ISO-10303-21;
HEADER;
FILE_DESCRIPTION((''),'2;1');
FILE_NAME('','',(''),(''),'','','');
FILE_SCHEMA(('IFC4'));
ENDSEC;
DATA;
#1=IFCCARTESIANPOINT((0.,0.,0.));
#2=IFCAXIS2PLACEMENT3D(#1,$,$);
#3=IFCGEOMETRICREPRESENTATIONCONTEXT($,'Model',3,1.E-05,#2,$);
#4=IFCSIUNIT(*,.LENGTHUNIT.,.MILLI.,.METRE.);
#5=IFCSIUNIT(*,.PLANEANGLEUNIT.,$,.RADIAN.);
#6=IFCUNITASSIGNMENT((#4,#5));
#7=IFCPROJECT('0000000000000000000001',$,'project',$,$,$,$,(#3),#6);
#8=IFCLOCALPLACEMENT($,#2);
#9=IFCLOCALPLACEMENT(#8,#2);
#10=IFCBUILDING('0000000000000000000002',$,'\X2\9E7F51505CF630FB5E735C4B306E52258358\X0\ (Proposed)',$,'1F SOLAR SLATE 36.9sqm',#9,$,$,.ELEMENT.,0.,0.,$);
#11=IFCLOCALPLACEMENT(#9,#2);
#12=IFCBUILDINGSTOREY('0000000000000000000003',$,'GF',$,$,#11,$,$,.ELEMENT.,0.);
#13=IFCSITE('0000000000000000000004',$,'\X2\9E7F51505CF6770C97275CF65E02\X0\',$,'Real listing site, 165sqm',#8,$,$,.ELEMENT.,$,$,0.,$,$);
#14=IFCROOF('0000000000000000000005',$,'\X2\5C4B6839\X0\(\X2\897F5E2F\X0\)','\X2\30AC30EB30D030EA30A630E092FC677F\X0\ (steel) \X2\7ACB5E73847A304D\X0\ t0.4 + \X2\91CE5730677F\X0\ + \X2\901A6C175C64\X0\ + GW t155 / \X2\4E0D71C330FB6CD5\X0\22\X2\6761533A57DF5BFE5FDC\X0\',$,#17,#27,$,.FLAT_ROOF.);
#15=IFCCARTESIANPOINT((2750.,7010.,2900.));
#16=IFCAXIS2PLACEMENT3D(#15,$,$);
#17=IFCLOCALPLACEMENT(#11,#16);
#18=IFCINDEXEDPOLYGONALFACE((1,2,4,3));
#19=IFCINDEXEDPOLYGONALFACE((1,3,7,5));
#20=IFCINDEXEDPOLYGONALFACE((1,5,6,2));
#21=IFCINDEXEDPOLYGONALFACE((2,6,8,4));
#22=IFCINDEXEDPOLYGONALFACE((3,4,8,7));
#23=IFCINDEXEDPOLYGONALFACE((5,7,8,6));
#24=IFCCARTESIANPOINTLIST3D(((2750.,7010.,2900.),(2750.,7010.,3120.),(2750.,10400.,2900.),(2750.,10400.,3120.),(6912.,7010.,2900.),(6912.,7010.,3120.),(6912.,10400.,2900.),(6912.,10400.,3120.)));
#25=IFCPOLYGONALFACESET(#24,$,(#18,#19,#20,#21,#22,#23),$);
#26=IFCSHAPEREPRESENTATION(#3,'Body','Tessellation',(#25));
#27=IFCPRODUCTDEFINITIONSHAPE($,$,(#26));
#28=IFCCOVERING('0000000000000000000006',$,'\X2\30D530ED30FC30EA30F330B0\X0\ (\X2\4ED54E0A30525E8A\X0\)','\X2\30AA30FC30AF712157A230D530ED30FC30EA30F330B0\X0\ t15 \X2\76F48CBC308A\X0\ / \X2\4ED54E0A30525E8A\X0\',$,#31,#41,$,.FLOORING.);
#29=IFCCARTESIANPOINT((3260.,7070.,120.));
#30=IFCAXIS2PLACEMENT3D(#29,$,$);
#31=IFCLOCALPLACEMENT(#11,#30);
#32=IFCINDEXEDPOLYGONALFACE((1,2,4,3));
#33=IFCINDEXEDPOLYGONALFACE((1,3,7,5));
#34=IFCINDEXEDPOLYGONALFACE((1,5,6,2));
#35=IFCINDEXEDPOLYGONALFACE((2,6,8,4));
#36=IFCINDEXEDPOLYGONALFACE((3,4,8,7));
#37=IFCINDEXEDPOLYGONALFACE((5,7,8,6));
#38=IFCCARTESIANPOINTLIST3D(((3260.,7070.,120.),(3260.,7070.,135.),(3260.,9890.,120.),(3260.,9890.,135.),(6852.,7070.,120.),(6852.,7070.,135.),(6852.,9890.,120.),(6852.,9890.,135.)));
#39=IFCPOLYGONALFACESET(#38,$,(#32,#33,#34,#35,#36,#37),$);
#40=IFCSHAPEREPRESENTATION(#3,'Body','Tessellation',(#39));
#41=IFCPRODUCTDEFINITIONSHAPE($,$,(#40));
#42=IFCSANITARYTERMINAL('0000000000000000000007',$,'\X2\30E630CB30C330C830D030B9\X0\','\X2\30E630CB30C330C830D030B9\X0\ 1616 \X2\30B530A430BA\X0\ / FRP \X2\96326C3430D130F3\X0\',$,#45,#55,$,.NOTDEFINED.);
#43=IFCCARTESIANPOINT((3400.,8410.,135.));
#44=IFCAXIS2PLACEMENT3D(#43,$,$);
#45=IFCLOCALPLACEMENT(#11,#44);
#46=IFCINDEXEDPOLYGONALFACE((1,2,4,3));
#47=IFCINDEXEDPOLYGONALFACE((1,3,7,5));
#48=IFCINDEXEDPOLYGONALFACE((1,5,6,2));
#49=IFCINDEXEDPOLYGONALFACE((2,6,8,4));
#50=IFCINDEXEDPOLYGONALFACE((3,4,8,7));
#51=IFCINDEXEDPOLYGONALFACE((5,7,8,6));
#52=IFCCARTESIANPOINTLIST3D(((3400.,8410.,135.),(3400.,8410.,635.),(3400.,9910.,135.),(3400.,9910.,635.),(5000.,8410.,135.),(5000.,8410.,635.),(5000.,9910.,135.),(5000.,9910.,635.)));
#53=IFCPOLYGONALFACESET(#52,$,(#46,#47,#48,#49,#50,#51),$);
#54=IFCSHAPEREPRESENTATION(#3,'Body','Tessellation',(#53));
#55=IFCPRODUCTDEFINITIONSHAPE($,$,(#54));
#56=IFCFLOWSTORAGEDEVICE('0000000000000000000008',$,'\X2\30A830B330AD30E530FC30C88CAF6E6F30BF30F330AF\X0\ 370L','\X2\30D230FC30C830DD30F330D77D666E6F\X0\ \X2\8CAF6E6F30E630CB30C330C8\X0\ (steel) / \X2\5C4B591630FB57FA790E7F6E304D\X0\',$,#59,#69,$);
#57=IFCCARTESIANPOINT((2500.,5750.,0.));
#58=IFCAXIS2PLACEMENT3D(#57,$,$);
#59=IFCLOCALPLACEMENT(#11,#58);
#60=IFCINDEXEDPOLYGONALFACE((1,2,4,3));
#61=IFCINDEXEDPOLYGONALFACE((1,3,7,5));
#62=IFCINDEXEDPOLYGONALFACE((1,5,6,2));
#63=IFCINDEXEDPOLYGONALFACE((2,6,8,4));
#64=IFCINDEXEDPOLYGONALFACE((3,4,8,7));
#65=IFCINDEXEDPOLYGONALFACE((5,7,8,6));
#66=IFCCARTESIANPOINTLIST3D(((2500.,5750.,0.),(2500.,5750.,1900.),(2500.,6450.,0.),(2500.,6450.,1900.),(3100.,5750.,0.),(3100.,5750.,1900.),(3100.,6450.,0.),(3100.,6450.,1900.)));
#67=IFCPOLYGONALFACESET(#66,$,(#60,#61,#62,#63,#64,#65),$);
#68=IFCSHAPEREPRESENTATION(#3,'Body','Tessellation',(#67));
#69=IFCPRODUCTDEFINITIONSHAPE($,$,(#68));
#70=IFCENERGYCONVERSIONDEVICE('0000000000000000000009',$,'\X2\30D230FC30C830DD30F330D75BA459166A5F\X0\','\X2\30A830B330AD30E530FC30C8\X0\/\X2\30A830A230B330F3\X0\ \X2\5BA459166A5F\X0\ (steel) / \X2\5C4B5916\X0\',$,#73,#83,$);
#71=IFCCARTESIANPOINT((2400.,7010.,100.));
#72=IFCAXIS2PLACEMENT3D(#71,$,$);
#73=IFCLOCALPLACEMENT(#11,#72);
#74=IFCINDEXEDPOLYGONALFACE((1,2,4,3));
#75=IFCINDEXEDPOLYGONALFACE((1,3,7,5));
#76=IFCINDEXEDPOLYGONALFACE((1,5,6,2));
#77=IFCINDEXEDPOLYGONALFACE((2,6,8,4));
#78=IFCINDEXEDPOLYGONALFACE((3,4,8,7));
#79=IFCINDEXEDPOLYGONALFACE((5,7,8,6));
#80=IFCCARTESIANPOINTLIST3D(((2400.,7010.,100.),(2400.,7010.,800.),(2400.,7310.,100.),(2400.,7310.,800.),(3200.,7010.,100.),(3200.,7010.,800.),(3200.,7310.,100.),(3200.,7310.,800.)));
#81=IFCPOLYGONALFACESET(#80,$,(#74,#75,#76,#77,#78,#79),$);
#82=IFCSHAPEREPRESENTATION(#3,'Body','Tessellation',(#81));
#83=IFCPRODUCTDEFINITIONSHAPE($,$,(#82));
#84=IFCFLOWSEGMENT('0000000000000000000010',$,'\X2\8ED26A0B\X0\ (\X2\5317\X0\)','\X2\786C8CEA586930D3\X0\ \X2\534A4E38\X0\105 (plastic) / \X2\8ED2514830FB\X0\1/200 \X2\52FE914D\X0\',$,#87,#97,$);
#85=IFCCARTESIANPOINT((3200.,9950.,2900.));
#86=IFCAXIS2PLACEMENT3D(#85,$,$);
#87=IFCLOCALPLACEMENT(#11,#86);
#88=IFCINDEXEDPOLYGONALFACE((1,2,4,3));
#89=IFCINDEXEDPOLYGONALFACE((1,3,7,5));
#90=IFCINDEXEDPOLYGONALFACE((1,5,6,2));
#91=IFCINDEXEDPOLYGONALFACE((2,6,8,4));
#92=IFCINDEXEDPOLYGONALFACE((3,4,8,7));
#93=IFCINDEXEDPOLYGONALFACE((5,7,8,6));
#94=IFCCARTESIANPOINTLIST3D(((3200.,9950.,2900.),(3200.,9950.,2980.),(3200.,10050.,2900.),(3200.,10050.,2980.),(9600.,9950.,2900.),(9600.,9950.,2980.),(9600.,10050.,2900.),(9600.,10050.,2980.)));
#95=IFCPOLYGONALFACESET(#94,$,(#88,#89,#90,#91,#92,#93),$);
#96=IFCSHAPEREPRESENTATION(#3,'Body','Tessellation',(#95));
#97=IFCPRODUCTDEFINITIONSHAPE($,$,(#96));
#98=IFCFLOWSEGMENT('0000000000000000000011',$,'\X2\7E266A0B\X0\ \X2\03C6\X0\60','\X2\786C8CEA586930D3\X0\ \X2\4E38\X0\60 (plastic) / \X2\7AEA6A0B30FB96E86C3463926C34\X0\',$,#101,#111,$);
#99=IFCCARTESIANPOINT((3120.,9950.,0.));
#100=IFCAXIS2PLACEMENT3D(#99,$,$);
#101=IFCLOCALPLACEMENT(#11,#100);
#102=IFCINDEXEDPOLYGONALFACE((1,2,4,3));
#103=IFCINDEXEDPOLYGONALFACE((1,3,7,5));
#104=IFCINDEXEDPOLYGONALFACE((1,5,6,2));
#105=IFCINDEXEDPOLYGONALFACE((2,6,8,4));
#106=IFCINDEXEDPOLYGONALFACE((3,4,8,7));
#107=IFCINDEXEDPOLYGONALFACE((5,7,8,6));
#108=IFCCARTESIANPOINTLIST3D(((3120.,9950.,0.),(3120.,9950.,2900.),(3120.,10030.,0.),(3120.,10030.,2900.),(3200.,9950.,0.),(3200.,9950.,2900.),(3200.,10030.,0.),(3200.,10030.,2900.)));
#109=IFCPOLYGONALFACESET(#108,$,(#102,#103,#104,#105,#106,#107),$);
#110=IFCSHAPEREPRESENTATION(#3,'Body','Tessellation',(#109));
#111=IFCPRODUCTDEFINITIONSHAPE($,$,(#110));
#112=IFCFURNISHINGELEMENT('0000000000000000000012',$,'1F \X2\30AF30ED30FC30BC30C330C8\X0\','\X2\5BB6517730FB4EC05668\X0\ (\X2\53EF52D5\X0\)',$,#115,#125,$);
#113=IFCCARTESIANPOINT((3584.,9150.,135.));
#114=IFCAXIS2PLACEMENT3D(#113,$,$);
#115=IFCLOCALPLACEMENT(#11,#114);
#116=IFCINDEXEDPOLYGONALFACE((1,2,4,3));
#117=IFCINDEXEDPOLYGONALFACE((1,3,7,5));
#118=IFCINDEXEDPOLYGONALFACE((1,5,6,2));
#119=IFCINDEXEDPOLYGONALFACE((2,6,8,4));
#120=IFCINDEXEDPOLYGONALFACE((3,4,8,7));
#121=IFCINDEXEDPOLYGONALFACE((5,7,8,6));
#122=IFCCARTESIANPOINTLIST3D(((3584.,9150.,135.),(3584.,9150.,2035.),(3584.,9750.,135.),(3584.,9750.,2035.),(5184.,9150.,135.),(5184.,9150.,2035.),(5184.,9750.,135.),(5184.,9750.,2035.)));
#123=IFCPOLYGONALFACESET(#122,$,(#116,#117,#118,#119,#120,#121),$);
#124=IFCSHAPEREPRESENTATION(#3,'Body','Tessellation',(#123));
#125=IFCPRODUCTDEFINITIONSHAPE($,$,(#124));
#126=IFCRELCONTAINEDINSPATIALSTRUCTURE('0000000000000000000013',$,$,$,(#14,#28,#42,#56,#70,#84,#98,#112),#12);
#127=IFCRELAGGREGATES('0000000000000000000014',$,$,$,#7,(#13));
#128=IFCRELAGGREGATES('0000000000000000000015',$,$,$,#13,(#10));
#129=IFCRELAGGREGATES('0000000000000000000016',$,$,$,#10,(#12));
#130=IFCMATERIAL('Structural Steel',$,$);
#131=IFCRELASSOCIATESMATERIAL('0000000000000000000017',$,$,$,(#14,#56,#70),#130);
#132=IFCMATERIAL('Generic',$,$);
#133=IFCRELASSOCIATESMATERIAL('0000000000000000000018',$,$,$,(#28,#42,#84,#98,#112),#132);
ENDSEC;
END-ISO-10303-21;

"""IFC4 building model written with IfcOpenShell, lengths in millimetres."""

from ifc_helpers import new_model, si_unit, frame, frame_2d, origin, place, context, project, spatial, rectangle, extrude, material, element, save


model = new_model("IFC4")

# Units and contexts
model_context = context("Model", 3, precision=1e-05, world=origin())
ifc_project = project(units=[si_unit("LENGTHUNIT", "METRE", prefix="MILLI"), si_unit("PLANEANGLEUNIT", "RADIAN")], contexts=[model_context])

# Site, building, storey
site_placement = place(None, origin())
site = spatial("IfcSite", under=ifc_project, at=site_placement, Name="鹿児島県霧島市", ObjectType="Real listing site, 165sqm", CompositionType="ELEMENT", RefElevation=0.0)
building_placement = place(site_placement, origin())
building = spatial("IfcBuilding", under=site, at=building_placement, Name="鹿児島・平屋の別荘 (Proposed)", ObjectType="1F SOLAR SLATE 36.9sqm", CompositionType="ELEMENT", ElevationOfRefHeight=0.0, ElevationOfTerrain=0.0)
storey_placement = place(building_placement, origin())
storey = spatial("IfcBuildingStorey", under=building, at=storey_placement, Name="GF", CompositionType="ELEMENT", Elevation=0.0)

# Roof
ifc_material_1 = material(Name="Structural Steel")
roof_placement = place(storey_placement, frame((2750.0, 7010.0, 2900.0)))
element("IfcRoof", 1, at=roof_placement, inside=storey, material=ifc_material_1, Name="屋根(西帯)", Description="ガルバリウム鋼板 (steel) 立平葺き t0.4 + 野地板 + 通気層 + GW t155 / 不燃・法22条区域対応", PredefinedType="FLAT_ROOF", context=model_context, shape_type="SweptSolid", body=[
    extrude(rectangle(XDim=4162.0, YDim=3390.0, at=frame_2d((2081.0, 1695.0))), frame((2750.0, 7010.0, 2900.0)), (0.0, 0.0, 1.0), 220.0),
])

# Covering
ifc_material_2 = material(Name="Generic")
covering_placement = place(storey_placement, frame((3260.0, 7070.0, 120.0)))
element("IfcCovering", 2, at=covering_placement, inside=storey, material=ifc_material_2, Name="フローリング (仕上げ床)", Description="オーク無垢フローリング t15 直貼り / 仕上げ床", PredefinedType="FLOORING", context=model_context, shape_type="SweptSolid", body=[
    extrude(rectangle(XDim=3592.0, YDim=2820.0, at=frame_2d((1796.0, 1410.0))), frame((3260.0, 7070.0, 120.0)), (0.0, 0.0, 1.0), 15.0),
])

# Sanitary terminal
sanitary_terminal_placement = place(storey_placement, frame((3400.0, 8410.0, 135.0)))
element("IfcSanitaryTerminal", 3, at=sanitary_terminal_placement, inside=storey, material=ifc_material_2, Name="ユニットバス", Description="ユニットバス 1616 サイズ / FRP 防水パン", PredefinedType="NOTDEFINED", context=model_context, shape_type="SweptSolid", body=[
    extrude(rectangle(XDim=1600.0, YDim=1500.0, at=frame_2d((800.0, 750.0))), frame((3400.0, 8410.0, 135.0)), (0.0, 0.0, 1.0), 500.0),
])

# Flow storage device
flow_storage_device_placement = place(storey_placement, frame((2500.0, 5750.0, 0.0)))
element("IfcFlowStorageDevice", 4, at=flow_storage_device_placement, inside=storey, material=ifc_material_1, Name="エコキュート貯湯タンク 370L", Description="ヒートポンプ給湯 貯湯ユニット (steel) / 屋外・基礎置き", context=model_context, shape_type="SweptSolid", body=[
    extrude(rectangle(XDim=600.0, YDim=700.0, at=frame_2d((300.0, 350.0))), frame((2500.0, 5750.0, 0.0)), (0.0, 0.0, 1.0), 1900.0),
])

# Energy conversion device
energy_conversion_device_placement = place(storey_placement, frame((2400.0, 7010.0, 100.0)))
element("IfcEnergyConversionDevice", 5, at=energy_conversion_device_placement, inside=storey, material=ifc_material_1, Name="ヒートポンプ室外機", Description="エコキュート/エアコン 室外機 (steel) / 屋外", context=model_context, shape_type="SweptSolid", body=[
    extrude(rectangle(XDim=800.0, YDim=300.0, at=frame_2d((400.0, 150.0))), frame((2400.0, 7010.0, 100.0)), (0.0, 0.0, 1.0), 700.0),
])

# Flow segments
flow_segment_1_placement = place(storey_placement, frame((3200.0, 9950.0, 2900.0)))
element("IfcFlowSegment", 6, at=flow_segment_1_placement, inside=storey, material=ifc_material_2, Name="軒樋 (北)", Description="硬質塩ビ 半丸105 (plastic) / 軒先・1/200 勾配", context=model_context, shape_type="SweptSolid", body=[
    extrude(rectangle(XDim=6400.0, YDim=100.0, at=frame_2d((3200.0, 50.0))), frame((3200.0, 9950.0, 2900.0)), (0.0, 0.0, 1.0), 80.0),
])
flow_segment_2_placement = place(storey_placement, frame((3120.0, 9950.0, 0.0)))
element("IfcFlowSegment", 7, at=flow_segment_2_placement, inside=storey, material=ifc_material_2, Name="縦樋 φ60", Description="硬質塩ビ 丸60 (plastic) / 竪樋・雨水排水", context=model_context, shape_type="SweptSolid", body=[
    extrude(rectangle(XDim=80.0, YDim=80.0, at=frame_2d((40.0, 40.0))), frame((3120.0, 9950.0, 0.0)), (0.0, 0.0, 1.0), 2900.0),
])

# Furnishing element
furnishing_placement = place(storey_placement, frame((3584.0, 9150.0, 135.0)))
element("IfcFurnishingElement", 8, at=furnishing_placement, inside=storey, material=ifc_material_2, Name="1F クローゼット", Description="家具・什器 (可動)", context=model_context, shape_type="SweptSolid", body=[
    extrude(rectangle(XDim=1600.0, YDim=600.0, at=frame_2d((800.0, 300.0))), frame((3584.0, 9150.0, 135.0)), (0.0, 0.0, 1.0), 1900.0),
])

save(model, "model.ifc")
